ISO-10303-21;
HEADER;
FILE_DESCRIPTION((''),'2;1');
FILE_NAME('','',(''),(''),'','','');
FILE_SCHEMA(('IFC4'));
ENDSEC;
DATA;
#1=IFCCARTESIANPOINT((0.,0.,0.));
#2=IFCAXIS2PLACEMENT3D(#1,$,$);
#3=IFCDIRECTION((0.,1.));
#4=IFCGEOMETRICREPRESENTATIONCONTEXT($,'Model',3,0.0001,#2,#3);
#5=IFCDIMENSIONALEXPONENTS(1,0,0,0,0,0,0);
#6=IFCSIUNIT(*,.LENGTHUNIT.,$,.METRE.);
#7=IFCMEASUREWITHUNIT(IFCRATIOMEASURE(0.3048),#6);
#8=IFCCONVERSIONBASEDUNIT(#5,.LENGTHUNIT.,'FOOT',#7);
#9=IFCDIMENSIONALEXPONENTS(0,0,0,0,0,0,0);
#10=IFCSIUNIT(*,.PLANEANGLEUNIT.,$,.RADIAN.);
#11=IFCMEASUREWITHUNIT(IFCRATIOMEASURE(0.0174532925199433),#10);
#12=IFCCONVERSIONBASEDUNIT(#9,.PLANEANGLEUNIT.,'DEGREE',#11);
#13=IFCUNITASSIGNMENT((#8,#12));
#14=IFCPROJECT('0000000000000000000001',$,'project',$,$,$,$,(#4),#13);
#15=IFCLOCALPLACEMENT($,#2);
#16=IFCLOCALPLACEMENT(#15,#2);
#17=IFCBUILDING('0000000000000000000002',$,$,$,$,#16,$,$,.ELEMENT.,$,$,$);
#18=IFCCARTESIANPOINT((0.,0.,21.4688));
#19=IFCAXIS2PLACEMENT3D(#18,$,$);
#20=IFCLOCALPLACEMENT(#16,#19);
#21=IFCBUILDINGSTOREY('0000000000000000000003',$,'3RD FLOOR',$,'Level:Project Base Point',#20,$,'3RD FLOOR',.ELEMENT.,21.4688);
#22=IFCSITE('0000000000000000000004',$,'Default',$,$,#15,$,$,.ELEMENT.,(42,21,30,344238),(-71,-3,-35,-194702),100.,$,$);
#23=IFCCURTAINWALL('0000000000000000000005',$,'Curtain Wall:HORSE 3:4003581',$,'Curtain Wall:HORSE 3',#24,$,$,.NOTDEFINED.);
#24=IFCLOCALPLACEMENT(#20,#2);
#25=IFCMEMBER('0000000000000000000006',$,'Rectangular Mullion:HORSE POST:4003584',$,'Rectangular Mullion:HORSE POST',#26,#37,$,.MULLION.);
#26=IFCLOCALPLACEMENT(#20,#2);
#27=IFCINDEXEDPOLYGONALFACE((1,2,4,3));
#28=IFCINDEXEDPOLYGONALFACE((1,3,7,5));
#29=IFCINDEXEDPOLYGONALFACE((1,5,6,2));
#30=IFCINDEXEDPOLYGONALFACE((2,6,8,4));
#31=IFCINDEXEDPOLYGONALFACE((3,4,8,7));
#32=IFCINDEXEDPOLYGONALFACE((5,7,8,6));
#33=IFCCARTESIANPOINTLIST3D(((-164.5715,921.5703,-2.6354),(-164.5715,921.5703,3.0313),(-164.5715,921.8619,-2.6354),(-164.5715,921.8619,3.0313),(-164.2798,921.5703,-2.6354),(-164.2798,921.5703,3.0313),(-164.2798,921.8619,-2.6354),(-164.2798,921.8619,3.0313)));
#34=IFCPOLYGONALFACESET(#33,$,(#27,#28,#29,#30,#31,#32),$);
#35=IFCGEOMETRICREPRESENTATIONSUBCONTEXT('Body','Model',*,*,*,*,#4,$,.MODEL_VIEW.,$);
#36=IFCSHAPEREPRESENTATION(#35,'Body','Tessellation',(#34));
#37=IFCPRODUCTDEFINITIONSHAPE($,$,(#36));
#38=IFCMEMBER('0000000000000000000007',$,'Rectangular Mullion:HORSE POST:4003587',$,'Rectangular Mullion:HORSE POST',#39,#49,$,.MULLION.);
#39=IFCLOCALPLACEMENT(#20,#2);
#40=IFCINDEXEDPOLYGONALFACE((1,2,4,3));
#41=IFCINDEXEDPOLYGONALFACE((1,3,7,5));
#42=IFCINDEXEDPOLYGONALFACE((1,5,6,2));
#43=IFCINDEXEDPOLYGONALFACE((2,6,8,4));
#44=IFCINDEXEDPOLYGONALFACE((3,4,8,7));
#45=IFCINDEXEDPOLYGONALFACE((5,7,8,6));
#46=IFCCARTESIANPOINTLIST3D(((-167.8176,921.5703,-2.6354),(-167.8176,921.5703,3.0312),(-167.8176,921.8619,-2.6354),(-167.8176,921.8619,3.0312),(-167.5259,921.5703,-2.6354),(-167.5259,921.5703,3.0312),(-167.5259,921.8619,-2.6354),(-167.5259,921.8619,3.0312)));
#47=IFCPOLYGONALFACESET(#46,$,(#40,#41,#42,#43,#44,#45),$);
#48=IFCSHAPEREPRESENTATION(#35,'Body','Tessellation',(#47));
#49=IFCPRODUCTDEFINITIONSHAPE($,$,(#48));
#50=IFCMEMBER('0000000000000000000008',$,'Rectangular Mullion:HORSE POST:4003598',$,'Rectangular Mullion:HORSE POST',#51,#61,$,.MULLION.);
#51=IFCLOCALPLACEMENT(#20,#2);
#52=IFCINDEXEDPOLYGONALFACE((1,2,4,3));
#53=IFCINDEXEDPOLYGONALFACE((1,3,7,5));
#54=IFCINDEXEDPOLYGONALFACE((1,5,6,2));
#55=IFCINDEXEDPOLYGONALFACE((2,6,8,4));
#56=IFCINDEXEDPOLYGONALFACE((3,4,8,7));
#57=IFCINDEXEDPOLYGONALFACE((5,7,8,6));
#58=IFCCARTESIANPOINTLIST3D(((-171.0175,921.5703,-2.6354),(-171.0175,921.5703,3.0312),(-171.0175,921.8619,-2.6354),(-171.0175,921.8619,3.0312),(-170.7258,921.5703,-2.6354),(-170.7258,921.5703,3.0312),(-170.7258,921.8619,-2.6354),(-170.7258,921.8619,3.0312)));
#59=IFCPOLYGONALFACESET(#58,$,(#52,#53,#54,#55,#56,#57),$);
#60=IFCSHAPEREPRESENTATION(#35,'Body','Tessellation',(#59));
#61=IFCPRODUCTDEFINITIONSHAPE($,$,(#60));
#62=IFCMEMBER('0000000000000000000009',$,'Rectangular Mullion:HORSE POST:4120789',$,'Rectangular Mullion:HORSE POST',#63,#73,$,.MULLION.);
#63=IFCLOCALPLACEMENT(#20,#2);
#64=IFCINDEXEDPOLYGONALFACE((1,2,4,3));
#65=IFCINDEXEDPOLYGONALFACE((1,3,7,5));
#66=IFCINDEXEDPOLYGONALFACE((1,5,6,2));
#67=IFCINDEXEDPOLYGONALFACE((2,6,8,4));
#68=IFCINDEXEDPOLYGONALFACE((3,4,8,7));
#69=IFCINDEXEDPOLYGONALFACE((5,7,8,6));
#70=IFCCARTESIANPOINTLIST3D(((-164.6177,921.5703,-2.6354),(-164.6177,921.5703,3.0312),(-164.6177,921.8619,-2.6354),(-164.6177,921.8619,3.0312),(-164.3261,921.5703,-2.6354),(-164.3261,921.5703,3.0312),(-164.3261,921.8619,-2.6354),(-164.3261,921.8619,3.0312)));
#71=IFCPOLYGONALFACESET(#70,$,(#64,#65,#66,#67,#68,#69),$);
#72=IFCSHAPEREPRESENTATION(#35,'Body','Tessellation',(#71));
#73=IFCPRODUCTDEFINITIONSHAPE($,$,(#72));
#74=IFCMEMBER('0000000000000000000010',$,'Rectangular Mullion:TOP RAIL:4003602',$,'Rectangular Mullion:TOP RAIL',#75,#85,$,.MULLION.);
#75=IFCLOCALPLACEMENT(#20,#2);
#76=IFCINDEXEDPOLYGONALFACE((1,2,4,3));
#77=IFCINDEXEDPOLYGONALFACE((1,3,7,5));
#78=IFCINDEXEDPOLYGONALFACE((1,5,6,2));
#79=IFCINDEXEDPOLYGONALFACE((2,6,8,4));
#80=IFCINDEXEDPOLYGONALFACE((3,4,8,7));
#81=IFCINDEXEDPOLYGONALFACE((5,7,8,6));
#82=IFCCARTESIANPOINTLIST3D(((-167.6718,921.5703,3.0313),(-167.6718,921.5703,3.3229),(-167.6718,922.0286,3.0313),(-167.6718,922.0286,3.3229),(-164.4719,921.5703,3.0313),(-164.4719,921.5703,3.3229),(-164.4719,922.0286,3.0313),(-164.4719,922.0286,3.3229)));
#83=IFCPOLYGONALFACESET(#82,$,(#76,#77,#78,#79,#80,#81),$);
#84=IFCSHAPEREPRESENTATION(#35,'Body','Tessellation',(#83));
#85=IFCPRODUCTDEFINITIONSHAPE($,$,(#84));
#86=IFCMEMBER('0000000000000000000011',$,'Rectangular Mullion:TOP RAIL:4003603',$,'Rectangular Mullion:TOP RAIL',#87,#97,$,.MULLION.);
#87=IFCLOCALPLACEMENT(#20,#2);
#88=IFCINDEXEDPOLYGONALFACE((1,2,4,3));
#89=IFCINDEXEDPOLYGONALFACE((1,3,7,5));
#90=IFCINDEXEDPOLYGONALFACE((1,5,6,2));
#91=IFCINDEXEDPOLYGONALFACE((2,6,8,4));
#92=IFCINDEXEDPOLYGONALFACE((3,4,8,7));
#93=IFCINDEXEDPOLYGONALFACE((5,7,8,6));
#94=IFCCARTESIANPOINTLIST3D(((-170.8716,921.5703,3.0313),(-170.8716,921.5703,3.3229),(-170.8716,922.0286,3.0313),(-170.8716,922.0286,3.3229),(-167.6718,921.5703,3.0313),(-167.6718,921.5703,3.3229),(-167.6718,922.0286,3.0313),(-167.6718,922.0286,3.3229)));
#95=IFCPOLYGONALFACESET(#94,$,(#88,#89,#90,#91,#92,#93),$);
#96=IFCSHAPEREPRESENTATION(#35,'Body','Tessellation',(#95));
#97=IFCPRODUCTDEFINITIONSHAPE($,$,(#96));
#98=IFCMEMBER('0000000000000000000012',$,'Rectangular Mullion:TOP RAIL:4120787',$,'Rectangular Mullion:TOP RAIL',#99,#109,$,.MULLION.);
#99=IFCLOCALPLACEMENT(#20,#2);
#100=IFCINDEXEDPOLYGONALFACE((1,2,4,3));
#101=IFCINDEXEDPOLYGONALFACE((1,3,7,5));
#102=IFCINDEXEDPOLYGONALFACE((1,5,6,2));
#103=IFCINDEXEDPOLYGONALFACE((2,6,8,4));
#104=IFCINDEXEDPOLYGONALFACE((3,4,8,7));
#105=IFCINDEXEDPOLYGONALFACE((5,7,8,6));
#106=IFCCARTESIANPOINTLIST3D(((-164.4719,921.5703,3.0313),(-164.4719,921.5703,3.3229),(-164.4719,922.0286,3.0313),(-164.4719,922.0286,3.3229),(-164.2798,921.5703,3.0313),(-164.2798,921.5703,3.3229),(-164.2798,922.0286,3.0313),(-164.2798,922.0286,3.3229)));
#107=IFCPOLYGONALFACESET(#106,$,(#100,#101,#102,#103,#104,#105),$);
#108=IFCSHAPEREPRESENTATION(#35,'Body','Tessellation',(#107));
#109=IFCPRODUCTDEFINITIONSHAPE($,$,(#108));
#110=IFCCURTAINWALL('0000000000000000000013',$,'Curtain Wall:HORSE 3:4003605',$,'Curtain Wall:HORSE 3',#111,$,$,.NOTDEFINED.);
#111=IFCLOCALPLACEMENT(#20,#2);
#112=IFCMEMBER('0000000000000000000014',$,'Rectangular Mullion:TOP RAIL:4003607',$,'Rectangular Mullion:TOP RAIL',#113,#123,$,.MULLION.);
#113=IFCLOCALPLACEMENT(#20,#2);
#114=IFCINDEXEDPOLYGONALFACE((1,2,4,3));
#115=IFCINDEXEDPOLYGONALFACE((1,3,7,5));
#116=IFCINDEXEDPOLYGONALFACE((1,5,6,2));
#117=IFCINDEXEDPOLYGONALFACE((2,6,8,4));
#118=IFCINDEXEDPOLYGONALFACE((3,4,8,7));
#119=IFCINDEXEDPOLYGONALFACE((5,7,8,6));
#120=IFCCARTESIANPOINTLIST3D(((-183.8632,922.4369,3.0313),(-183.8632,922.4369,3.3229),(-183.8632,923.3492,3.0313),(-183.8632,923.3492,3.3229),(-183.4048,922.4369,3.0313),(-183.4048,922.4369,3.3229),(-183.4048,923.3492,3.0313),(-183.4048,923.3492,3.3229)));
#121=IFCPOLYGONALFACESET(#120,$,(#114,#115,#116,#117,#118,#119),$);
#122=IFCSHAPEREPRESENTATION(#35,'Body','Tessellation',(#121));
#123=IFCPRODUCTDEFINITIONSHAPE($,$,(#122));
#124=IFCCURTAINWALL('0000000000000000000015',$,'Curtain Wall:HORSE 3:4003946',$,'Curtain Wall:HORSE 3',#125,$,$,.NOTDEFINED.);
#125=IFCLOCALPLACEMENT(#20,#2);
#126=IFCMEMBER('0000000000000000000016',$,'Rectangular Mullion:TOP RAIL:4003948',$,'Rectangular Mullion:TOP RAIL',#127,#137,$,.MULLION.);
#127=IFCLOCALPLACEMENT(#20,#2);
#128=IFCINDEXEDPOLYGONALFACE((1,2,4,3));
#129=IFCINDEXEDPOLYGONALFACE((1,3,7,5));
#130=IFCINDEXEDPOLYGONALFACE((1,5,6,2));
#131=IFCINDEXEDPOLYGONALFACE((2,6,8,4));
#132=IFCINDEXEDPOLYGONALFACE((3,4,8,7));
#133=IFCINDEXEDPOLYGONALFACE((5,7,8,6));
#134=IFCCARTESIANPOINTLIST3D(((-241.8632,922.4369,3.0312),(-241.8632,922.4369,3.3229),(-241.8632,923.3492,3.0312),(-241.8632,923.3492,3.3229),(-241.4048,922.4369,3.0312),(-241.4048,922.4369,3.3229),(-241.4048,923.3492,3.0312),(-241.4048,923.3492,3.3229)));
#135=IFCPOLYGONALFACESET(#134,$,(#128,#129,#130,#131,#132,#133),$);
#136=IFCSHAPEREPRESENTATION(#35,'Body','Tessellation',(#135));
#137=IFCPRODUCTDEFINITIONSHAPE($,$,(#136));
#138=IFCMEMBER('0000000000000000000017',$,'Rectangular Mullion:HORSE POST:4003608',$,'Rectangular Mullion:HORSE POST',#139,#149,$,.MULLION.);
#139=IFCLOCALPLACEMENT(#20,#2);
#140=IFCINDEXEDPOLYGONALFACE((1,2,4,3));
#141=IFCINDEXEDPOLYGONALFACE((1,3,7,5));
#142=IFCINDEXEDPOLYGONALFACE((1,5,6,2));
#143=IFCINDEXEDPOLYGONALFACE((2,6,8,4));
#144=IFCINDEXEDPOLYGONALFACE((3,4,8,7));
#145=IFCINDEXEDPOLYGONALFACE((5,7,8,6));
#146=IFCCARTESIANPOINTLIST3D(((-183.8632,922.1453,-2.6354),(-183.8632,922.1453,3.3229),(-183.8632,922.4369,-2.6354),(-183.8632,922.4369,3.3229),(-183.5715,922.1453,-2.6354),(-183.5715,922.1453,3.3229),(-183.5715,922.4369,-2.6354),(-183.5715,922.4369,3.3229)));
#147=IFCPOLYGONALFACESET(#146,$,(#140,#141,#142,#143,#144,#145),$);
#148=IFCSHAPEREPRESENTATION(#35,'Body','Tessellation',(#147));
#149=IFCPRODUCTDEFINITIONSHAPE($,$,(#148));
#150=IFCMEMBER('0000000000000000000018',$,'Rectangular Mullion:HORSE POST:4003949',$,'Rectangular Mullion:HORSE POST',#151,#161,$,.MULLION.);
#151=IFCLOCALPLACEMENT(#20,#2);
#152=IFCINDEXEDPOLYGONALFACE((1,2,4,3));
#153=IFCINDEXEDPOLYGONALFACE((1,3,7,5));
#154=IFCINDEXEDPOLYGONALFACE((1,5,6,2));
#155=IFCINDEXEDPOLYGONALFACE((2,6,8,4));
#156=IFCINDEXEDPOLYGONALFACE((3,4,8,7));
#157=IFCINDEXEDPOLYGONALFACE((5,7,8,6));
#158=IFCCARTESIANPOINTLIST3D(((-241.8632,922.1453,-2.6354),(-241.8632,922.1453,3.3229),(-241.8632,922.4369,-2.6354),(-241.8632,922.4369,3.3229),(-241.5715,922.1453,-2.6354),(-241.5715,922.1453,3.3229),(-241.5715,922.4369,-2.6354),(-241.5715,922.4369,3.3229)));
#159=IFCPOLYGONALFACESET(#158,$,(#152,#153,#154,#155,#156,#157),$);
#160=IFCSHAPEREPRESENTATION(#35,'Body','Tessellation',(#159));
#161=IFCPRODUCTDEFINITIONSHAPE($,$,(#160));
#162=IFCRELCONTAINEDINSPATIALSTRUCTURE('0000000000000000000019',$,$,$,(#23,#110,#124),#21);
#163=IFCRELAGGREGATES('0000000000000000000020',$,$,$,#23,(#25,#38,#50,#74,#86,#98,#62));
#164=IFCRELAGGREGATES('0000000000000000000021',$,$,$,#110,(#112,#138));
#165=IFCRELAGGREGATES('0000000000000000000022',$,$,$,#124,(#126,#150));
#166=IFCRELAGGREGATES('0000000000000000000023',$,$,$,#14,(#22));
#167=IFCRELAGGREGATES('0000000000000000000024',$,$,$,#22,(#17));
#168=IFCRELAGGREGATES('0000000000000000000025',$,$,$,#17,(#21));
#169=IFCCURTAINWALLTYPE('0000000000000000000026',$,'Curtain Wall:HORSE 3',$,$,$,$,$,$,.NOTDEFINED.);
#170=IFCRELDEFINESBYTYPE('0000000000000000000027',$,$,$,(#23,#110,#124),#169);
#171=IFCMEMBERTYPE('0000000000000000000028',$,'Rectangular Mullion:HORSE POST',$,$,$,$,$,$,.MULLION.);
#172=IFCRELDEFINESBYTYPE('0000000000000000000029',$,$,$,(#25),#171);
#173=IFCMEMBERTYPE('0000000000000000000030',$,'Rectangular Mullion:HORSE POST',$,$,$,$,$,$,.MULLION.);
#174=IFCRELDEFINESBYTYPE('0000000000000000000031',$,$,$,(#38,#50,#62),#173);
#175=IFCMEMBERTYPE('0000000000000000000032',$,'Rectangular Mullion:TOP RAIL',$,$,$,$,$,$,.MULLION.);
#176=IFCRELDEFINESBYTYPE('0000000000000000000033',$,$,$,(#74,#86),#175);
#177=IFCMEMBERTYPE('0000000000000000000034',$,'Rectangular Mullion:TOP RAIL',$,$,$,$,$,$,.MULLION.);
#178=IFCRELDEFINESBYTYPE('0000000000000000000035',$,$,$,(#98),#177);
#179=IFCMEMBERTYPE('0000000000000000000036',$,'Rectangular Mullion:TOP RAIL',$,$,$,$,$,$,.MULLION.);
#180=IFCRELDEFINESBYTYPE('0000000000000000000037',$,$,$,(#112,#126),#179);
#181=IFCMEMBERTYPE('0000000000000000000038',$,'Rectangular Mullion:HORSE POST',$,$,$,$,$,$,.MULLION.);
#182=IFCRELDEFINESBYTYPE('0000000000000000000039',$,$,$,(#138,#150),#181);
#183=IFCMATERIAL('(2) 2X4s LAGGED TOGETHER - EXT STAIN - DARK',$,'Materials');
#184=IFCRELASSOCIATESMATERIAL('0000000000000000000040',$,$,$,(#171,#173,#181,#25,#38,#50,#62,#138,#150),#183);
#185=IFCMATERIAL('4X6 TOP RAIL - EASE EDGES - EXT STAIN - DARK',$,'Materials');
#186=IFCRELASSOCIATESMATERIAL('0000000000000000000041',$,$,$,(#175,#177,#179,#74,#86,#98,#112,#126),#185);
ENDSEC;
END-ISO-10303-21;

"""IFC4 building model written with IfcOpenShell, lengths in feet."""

from ifc_helpers import new_model, entity, si_unit, converted_unit, direction, frame, frame_2d, origin, origin_2d_with_axis, place, context, subcontext, project, spatial, rectangle, extrude, source, transform, mapped, material, material_profile, profile_set, profile_usage, type_object, type_shapes, element, aggregate, save


model = new_model("IFC4")

# Units and contexts
model_context = context("Model", 3, precision=0.0001, world=origin(), true_north=direction((0.0, 1.0)))
body_context = subcontext(model_context, "Body", "Model", "MODEL_VIEW")
ifc_project = project(units=[converted_unit("LENGTHUNIT", "FOOT", entity("IfcRatioMeasure", 0.3048), si_unit("LENGTHUNIT", "METRE"), dimensions=[1, 0, 0, 0, 0, 0, 0]), converted_unit("PLANEANGLEUNIT", "DEGREE", entity("IfcRatioMeasure", 0.0174532925199433), si_unit("PLANEANGLEUNIT", "RADIAN"), dimensions=[0, 0, 0, 0, 0, 0, 0])], contexts=[model_context])

# Site, building, storey
site_placement = place(None, origin())
site = spatial("IfcSite", under=ifc_project, at=site_placement, Name="Default", CompositionType="ELEMENT", RefLatitude=(42, 21, 30, 344238), RefLongitude=(-71, -3, -35, -194702), RefElevation=100.0)
building_placement = place(site_placement, origin())
building = spatial("IfcBuilding", under=site, at=building_placement, CompositionType="ELEMENT")
storey_placement = place(building_placement, frame((0.0, 0.0, 21.4688)))
storey = spatial("IfcBuildingStorey", under=building, at=storey_placement, Name="3RD FLOOR", ObjectType="Level:Project Base Point", LongName="3RD FLOOR", CompositionType="ELEMENT", Elevation=21.4688)

# Curtain wall, members
curtain_wall_type = type_object("IfcCurtainWallType", Name="Curtain Wall:HORSE 3", PredefinedType="NOTDEFINED")
curtain_wall_1_placement = place(storey_placement, frame((0.0, 0.0, -21.4688)))
curtain_wall_1 = element("IfcCurtainWall", 1, at=curtain_wall_1_placement, inside=storey, type_object=curtain_wall_type, Name="Curtain Wall:HORSE 3:4003581", ObjectType="Curtain Wall:HORSE 3", PredefinedType="NOTDEFINED")
ifc_material_1 = material(Name="(2) 2X4s LAGGED TOGETHER - EXT STAIN - DARK", Category="Materials")
ifc_material_profile_1 = material_profile(ifc_material_1, rectangle(XDim=0.2917, YDim=0.2917, at=frame_2d((0.0, 0.0), x_axis=(1.0, 0.0))), Name="HORSE POST")
ifc_profile_set_1 = profile_set([ifc_material_profile_1], Name="HORSE POST")
ifc_profile_usage_1 = profile_usage(ifc_profile_set_1)
member_type_1 = type_object("IfcMemberType", Name="Rectangular Mullion:HORSE POST", PredefinedType="MULLION", material=ifc_profile_set_1)
shared_shape_1 = source(origin(), body_context, "Body", "SweptSolid", [
    extrude(rectangle(XDim=0.2917, YDim=0.2917, at=frame_2d((0.0, 0.0), x_axis=(1.0, 0.0))), frame((-0.1458, -0.1458, -5.6667), z_axis=(0.0, 0.0, 1.0), x_axis=(0.0, -1.0, 0.0)), (0.0, 0.0, 1.0), 5.6667),
])
type_shapes(member_type_1, [shared_shape_1])
member_1_placement = place(storey_placement, frame((-164.2798, 921.8619, 3.0313)))
member_1 = element("IfcMember", 2, at=member_1_placement, type_object=member_type_1, material=ifc_profile_usage_1, Name="Rectangular Mullion:HORSE POST:4003584", ObjectType="Rectangular Mullion:HORSE POST", PredefinedType="MULLION", context=body_context, shape_type="MappedRepresentation", body=[
    mapped(shared_shape_1, transform((0.0, 0.0, 0.0), scale=1.0)),
])
ifc_profile_usage_2 = profile_usage(ifc_profile_set_1)
member_type_2 = type_object("IfcMemberType", Name="Rectangular Mullion:HORSE POST", PredefinedType="MULLION", material=ifc_profile_set_1)
shared_shape_2 = source(origin(), body_context, "Body", "SweptSolid", [
    extrude(rectangle(XDim=0.2917, YDim=0.2917, at=frame_2d((0.0, 0.0), x_axis=(1.0, 0.0))), frame((0.0, -0.1458, -5.6667), z_axis=(0.0, 0.0, 1.0), x_axis=(0.0, -1.0, 0.0)), (0.0, 0.0, 1.0), 5.6667),
])
type_shapes(member_type_2, [shared_shape_2])
member_2_placement = place(storey_placement, frame((-167.6718, 921.8619, -2.6354), z_axis=(0.0, 0.0, -1.0), x_axis=(-1.0, 0.0, 0.0)))
member_2 = element("IfcMember", 3, at=member_2_placement, type_object=member_type_2, material=ifc_profile_usage_2, Name="Rectangular Mullion:HORSE POST:4003587", ObjectType="Rectangular Mullion:HORSE POST", PredefinedType="MULLION", context=body_context, shape_type="MappedRepresentation", body=[
    mapped(shared_shape_2, transform((0.0, 0.0, 0.0), scale=1.0)),
])
ifc_profile_usage_3 = profile_usage(ifc_profile_set_1)
member_3_placement = place(storey_placement, frame((-170.8716, 921.8619, -2.6354), z_axis=(0.0, 0.0, -1.0), x_axis=(-1.0, 0.0, 0.0)))
member_3 = element("IfcMember", 4, at=member_3_placement, type_object=member_type_2, material=ifc_profile_usage_3, Name="Rectangular Mullion:HORSE POST:4003598", ObjectType="Rectangular Mullion:HORSE POST", PredefinedType="MULLION", context=body_context, shape_type="MappedRepresentation", body=[
    mapped(shared_shape_2, transform((0.0, 0.0, 0.0), scale=1.0)),
])
ifc_profile_usage_4 = profile_usage(ifc_profile_set_1)
member_4_placement = place(storey_placement, frame((-164.4719, 921.8619, -2.6354), z_axis=(0.0, 0.0, -1.0), x_axis=(-1.0, 0.0, 0.0)))
member_4 = element("IfcMember", 5, at=member_4_placement, type_object=member_type_2, material=ifc_profile_usage_4, Name="Rectangular Mullion:HORSE POST:4120789", ObjectType="Rectangular Mullion:HORSE POST", PredefinedType="MULLION", context=body_context, shape_type="MappedRepresentation", body=[
    mapped(shared_shape_2, transform((0.0, 0.0, 0.0), scale=1.0)),
])
ifc_material_2 = material(Name="4X6 TOP RAIL - EASE EDGES - EXT STAIN - DARK", Category="Materials")
ifc_material_profile_2 = material_profile(ifc_material_2, rectangle(XDim=0.4583, YDim=0.2917, at=origin_2d_with_axis()), Name="TOP RAIL")
ifc_profile_set_2 = profile_set([ifc_material_profile_2], Name="TOP RAIL")
ifc_profile_usage_5 = profile_usage(ifc_profile_set_2)
member_type_3 = type_object("IfcMemberType", Name="Rectangular Mullion:TOP RAIL", PredefinedType="MULLION", material=ifc_profile_set_2)
shared_shape_3 = source(origin(), body_context, "Body", "SweptSolid", [
    extrude(rectangle(XDim=0.4583, YDim=0.2917, at=origin_2d_with_axis()), frame((-0.1458, -0.0625, -3.1999), z_axis=(0.0, 0.0, 1.0), x_axis=(0.0, -1.0, 0.0)), (0.0, 0.0, 1.0), 3.1999),
])
type_shapes(member_type_3, [shared_shape_3])
member_5_placement = place(storey_placement, frame((-167.6718, 921.8619, 3.3229), z_axis=(-1.0, 0.0, 0.0), x_axis=(0.0, 0.0, 1.0)))
member_5 = element("IfcMember", 6, at=member_5_placement, type_object=member_type_3, material=ifc_profile_usage_5, Name="Rectangular Mullion:TOP RAIL:4003602", ObjectType="Rectangular Mullion:TOP RAIL", PredefinedType="MULLION", context=body_context, shape_type="MappedRepresentation", body=[
    mapped(shared_shape_3, transform((0.0, 0.0, 0.0), scale=1.0)),
])
ifc_profile_usage_6 = profile_usage(ifc_profile_set_2)
member_6_placement = place(storey_placement, frame((-170.8716, 921.8619, 3.3229), z_axis=(-1.0, 0.0, 0.0), x_axis=(0.0, 0.0, 1.0)))
member_6 = element("IfcMember", 7, at=member_6_placement, type_object=member_type_3, material=ifc_profile_usage_6, Name="Rectangular Mullion:TOP RAIL:4003603", ObjectType="Rectangular Mullion:TOP RAIL", PredefinedType="MULLION", context=body_context, shape_type="MappedRepresentation", body=[
    mapped(shared_shape_3, transform((0.0, 0.0, 0.0), scale=1.0)),
])
ifc_profile_usage_7 = profile_usage(ifc_profile_set_2)
member_type_4 = type_object("IfcMemberType", Name="Rectangular Mullion:TOP RAIL", PredefinedType="MULLION", material=ifc_profile_set_2)
shared_shape_4 = source(origin(), body_context, "Body", "SweptSolid", [
    extrude(rectangle(XDim=0.4583, YDim=0.2917, at=origin_2d_with_axis()), frame((-0.1458, -0.0625, -0.1921), z_axis=(0.0, 0.0, 1.0), x_axis=(0.0, -1.0, 0.0)), (0.0, 0.0, 1.0), 0.1921),
])
type_shapes(member_type_4, [shared_shape_4])
member_7_placement = place(storey_placement, frame((-164.4719, 921.8619, 3.3229), z_axis=(-1.0, 0.0, 0.0), x_axis=(0.0, 0.0, 1.0)))
member_7 = element("IfcMember", 8, at=member_7_placement, type_object=member_type_4, material=ifc_profile_usage_7, Name="Rectangular Mullion:TOP RAIL:4120787", ObjectType="Rectangular Mullion:TOP RAIL", PredefinedType="MULLION", context=body_context, shape_type="MappedRepresentation", body=[
    mapped(shared_shape_4, transform((0.0, 0.0, 0.0), scale=1.0)),
])
aggregate(curtain_wall_1, [member_1, member_2, member_3, member_5, member_6, member_7, member_4])

# Curtain walls, members
curtain_wall_2_placement = place(storey_placement, frame((0.0, 0.0, -21.4688)))
curtain_wall_2 = element("IfcCurtainWall", 9, at=curtain_wall_2_placement, inside=storey, type_object=curtain_wall_type, Name="Curtain Wall:HORSE 3:4003605", ObjectType="Curtain Wall:HORSE 3", PredefinedType="NOTDEFINED")
ifc_profile_usage_8 = profile_usage(ifc_profile_set_2)
member_type_5 = type_object("IfcMemberType", Name="Rectangular Mullion:TOP RAIL", PredefinedType="MULLION", material=ifc_profile_set_2)
shared_shape_5 = source(origin(), body_context, "Body", "SweptSolid", [
    extrude(rectangle(XDim=0.4583, YDim=0.2917, at=origin_2d_with_axis()), frame((-0.1458, 0.0625, -0.9123), z_axis=(0.0, 0.0, 1.0), x_axis=(0.0, -1.0, 0.0)), (0.0, 0.0, 1.0), 0.9123),
])
type_shapes(member_type_5, [shared_shape_5])
member_8_placement = place(storey_placement, frame((-183.5715, 922.4369, 3.3229), z_axis=(0.0, -1.0, 0.0), x_axis=(0.0, 0.0, 1.0)))
member_8 = element("IfcMember", 10, at=member_8_placement, type_object=member_type_5, material=ifc_profile_usage_8, Name="Rectangular Mullion:TOP RAIL:4003607", ObjectType="Rectangular Mullion:TOP RAIL", PredefinedType="MULLION", context=body_context, shape_type="MappedRepresentation", body=[
    mapped(shared_shape_5, transform((0.0, 0.0, 0.0), scale=1.0)),
])
curtain_wall_3_placement = place(storey_placement, frame((0.0, 0.0, -21.4688)))
curtain_wall_3 = element("IfcCurtainWall", 11, at=curtain_wall_3_placement, inside=storey, type_object=curtain_wall_type, Name="Curtain Wall:HORSE 3:4003946", ObjectType="Curtain Wall:HORSE 3", PredefinedType="NOTDEFINED")
ifc_profile_usage_9 = profile_usage(ifc_profile_set_2)
member_9_placement = place(storey_placement, frame((-241.5715, 922.4369, 3.3229), z_axis=(0.0, -1.0, 0.0), x_axis=(0.0, 0.0, 1.0)))
member_9 = element("IfcMember", 12, at=member_9_placement, type_object=member_type_5, material=ifc_profile_usage_9, Name="Rectangular Mullion:TOP RAIL:4003948", ObjectType="Rectangular Mullion:TOP RAIL", PredefinedType="MULLION", context=body_context, shape_type="MappedRepresentation", body=[
    mapped(shared_shape_5, transform((0.0, 0.0, 0.0), scale=1.0)),
])

# Members
ifc_profile_usage_10 = profile_usage(ifc_profile_set_1)
member_type_6 = type_object("IfcMemberType", Name="Rectangular Mullion:HORSE POST", PredefinedType="MULLION", material=ifc_profile_set_1)
shared_shape_6 = source(origin(), body_context, "Body", "SweptSolid", [
    extrude(rectangle(XDim=0.2917, YDim=0.2917, at=origin_2d_with_axis()), frame((-0.1458, 0.1458, -5.9583), z_axis=(0.0, 0.0, 1.0), x_axis=(0.0, -1.0, 0.0)), (0.0, 0.0, 1.0), 5.9583),
])
type_shapes(member_type_6, [shared_shape_6])
member_10_placement = place(storey_placement, frame((-183.5715, 922.1453, -2.6354), z_axis=(0.0, 0.0, -1.0), x_axis=(0.0, -1.0, 0.0)))
member_10 = element("IfcMember", 13, at=member_10_placement, type_object=member_type_6, material=ifc_profile_usage_10, Name="Rectangular Mullion:HORSE POST:4003608", ObjectType="Rectangular Mullion:HORSE POST", PredefinedType="MULLION", context=body_context, shape_type="MappedRepresentation", body=[
    mapped(shared_shape_6, transform((0.0, 0.0, 0.0), scale=1.0)),
])
ifc_profile_usage_11 = profile_usage(ifc_profile_set_1)
member_11_placement = place(storey_placement, frame((-241.5715, 922.1453, -2.6354), z_axis=(0.0, 0.0, -1.0), x_axis=(0.0, -1.0, 0.0)))
member_11 = element("IfcMember", 14, at=member_11_placement, type_object=member_type_6, material=ifc_profile_usage_11, Name="Rectangular Mullion:HORSE POST:4003949", ObjectType="Rectangular Mullion:HORSE POST", PredefinedType="MULLION", context=body_context, shape_type="MappedRepresentation", body=[
    mapped(shared_shape_6, transform((0.0, 0.0, 0.0), scale=1.0)),
])

aggregate(curtain_wall_2, [member_8, member_10])
aggregate(curtain_wall_3, [member_9, member_11])

save(model, "model.ifc")
